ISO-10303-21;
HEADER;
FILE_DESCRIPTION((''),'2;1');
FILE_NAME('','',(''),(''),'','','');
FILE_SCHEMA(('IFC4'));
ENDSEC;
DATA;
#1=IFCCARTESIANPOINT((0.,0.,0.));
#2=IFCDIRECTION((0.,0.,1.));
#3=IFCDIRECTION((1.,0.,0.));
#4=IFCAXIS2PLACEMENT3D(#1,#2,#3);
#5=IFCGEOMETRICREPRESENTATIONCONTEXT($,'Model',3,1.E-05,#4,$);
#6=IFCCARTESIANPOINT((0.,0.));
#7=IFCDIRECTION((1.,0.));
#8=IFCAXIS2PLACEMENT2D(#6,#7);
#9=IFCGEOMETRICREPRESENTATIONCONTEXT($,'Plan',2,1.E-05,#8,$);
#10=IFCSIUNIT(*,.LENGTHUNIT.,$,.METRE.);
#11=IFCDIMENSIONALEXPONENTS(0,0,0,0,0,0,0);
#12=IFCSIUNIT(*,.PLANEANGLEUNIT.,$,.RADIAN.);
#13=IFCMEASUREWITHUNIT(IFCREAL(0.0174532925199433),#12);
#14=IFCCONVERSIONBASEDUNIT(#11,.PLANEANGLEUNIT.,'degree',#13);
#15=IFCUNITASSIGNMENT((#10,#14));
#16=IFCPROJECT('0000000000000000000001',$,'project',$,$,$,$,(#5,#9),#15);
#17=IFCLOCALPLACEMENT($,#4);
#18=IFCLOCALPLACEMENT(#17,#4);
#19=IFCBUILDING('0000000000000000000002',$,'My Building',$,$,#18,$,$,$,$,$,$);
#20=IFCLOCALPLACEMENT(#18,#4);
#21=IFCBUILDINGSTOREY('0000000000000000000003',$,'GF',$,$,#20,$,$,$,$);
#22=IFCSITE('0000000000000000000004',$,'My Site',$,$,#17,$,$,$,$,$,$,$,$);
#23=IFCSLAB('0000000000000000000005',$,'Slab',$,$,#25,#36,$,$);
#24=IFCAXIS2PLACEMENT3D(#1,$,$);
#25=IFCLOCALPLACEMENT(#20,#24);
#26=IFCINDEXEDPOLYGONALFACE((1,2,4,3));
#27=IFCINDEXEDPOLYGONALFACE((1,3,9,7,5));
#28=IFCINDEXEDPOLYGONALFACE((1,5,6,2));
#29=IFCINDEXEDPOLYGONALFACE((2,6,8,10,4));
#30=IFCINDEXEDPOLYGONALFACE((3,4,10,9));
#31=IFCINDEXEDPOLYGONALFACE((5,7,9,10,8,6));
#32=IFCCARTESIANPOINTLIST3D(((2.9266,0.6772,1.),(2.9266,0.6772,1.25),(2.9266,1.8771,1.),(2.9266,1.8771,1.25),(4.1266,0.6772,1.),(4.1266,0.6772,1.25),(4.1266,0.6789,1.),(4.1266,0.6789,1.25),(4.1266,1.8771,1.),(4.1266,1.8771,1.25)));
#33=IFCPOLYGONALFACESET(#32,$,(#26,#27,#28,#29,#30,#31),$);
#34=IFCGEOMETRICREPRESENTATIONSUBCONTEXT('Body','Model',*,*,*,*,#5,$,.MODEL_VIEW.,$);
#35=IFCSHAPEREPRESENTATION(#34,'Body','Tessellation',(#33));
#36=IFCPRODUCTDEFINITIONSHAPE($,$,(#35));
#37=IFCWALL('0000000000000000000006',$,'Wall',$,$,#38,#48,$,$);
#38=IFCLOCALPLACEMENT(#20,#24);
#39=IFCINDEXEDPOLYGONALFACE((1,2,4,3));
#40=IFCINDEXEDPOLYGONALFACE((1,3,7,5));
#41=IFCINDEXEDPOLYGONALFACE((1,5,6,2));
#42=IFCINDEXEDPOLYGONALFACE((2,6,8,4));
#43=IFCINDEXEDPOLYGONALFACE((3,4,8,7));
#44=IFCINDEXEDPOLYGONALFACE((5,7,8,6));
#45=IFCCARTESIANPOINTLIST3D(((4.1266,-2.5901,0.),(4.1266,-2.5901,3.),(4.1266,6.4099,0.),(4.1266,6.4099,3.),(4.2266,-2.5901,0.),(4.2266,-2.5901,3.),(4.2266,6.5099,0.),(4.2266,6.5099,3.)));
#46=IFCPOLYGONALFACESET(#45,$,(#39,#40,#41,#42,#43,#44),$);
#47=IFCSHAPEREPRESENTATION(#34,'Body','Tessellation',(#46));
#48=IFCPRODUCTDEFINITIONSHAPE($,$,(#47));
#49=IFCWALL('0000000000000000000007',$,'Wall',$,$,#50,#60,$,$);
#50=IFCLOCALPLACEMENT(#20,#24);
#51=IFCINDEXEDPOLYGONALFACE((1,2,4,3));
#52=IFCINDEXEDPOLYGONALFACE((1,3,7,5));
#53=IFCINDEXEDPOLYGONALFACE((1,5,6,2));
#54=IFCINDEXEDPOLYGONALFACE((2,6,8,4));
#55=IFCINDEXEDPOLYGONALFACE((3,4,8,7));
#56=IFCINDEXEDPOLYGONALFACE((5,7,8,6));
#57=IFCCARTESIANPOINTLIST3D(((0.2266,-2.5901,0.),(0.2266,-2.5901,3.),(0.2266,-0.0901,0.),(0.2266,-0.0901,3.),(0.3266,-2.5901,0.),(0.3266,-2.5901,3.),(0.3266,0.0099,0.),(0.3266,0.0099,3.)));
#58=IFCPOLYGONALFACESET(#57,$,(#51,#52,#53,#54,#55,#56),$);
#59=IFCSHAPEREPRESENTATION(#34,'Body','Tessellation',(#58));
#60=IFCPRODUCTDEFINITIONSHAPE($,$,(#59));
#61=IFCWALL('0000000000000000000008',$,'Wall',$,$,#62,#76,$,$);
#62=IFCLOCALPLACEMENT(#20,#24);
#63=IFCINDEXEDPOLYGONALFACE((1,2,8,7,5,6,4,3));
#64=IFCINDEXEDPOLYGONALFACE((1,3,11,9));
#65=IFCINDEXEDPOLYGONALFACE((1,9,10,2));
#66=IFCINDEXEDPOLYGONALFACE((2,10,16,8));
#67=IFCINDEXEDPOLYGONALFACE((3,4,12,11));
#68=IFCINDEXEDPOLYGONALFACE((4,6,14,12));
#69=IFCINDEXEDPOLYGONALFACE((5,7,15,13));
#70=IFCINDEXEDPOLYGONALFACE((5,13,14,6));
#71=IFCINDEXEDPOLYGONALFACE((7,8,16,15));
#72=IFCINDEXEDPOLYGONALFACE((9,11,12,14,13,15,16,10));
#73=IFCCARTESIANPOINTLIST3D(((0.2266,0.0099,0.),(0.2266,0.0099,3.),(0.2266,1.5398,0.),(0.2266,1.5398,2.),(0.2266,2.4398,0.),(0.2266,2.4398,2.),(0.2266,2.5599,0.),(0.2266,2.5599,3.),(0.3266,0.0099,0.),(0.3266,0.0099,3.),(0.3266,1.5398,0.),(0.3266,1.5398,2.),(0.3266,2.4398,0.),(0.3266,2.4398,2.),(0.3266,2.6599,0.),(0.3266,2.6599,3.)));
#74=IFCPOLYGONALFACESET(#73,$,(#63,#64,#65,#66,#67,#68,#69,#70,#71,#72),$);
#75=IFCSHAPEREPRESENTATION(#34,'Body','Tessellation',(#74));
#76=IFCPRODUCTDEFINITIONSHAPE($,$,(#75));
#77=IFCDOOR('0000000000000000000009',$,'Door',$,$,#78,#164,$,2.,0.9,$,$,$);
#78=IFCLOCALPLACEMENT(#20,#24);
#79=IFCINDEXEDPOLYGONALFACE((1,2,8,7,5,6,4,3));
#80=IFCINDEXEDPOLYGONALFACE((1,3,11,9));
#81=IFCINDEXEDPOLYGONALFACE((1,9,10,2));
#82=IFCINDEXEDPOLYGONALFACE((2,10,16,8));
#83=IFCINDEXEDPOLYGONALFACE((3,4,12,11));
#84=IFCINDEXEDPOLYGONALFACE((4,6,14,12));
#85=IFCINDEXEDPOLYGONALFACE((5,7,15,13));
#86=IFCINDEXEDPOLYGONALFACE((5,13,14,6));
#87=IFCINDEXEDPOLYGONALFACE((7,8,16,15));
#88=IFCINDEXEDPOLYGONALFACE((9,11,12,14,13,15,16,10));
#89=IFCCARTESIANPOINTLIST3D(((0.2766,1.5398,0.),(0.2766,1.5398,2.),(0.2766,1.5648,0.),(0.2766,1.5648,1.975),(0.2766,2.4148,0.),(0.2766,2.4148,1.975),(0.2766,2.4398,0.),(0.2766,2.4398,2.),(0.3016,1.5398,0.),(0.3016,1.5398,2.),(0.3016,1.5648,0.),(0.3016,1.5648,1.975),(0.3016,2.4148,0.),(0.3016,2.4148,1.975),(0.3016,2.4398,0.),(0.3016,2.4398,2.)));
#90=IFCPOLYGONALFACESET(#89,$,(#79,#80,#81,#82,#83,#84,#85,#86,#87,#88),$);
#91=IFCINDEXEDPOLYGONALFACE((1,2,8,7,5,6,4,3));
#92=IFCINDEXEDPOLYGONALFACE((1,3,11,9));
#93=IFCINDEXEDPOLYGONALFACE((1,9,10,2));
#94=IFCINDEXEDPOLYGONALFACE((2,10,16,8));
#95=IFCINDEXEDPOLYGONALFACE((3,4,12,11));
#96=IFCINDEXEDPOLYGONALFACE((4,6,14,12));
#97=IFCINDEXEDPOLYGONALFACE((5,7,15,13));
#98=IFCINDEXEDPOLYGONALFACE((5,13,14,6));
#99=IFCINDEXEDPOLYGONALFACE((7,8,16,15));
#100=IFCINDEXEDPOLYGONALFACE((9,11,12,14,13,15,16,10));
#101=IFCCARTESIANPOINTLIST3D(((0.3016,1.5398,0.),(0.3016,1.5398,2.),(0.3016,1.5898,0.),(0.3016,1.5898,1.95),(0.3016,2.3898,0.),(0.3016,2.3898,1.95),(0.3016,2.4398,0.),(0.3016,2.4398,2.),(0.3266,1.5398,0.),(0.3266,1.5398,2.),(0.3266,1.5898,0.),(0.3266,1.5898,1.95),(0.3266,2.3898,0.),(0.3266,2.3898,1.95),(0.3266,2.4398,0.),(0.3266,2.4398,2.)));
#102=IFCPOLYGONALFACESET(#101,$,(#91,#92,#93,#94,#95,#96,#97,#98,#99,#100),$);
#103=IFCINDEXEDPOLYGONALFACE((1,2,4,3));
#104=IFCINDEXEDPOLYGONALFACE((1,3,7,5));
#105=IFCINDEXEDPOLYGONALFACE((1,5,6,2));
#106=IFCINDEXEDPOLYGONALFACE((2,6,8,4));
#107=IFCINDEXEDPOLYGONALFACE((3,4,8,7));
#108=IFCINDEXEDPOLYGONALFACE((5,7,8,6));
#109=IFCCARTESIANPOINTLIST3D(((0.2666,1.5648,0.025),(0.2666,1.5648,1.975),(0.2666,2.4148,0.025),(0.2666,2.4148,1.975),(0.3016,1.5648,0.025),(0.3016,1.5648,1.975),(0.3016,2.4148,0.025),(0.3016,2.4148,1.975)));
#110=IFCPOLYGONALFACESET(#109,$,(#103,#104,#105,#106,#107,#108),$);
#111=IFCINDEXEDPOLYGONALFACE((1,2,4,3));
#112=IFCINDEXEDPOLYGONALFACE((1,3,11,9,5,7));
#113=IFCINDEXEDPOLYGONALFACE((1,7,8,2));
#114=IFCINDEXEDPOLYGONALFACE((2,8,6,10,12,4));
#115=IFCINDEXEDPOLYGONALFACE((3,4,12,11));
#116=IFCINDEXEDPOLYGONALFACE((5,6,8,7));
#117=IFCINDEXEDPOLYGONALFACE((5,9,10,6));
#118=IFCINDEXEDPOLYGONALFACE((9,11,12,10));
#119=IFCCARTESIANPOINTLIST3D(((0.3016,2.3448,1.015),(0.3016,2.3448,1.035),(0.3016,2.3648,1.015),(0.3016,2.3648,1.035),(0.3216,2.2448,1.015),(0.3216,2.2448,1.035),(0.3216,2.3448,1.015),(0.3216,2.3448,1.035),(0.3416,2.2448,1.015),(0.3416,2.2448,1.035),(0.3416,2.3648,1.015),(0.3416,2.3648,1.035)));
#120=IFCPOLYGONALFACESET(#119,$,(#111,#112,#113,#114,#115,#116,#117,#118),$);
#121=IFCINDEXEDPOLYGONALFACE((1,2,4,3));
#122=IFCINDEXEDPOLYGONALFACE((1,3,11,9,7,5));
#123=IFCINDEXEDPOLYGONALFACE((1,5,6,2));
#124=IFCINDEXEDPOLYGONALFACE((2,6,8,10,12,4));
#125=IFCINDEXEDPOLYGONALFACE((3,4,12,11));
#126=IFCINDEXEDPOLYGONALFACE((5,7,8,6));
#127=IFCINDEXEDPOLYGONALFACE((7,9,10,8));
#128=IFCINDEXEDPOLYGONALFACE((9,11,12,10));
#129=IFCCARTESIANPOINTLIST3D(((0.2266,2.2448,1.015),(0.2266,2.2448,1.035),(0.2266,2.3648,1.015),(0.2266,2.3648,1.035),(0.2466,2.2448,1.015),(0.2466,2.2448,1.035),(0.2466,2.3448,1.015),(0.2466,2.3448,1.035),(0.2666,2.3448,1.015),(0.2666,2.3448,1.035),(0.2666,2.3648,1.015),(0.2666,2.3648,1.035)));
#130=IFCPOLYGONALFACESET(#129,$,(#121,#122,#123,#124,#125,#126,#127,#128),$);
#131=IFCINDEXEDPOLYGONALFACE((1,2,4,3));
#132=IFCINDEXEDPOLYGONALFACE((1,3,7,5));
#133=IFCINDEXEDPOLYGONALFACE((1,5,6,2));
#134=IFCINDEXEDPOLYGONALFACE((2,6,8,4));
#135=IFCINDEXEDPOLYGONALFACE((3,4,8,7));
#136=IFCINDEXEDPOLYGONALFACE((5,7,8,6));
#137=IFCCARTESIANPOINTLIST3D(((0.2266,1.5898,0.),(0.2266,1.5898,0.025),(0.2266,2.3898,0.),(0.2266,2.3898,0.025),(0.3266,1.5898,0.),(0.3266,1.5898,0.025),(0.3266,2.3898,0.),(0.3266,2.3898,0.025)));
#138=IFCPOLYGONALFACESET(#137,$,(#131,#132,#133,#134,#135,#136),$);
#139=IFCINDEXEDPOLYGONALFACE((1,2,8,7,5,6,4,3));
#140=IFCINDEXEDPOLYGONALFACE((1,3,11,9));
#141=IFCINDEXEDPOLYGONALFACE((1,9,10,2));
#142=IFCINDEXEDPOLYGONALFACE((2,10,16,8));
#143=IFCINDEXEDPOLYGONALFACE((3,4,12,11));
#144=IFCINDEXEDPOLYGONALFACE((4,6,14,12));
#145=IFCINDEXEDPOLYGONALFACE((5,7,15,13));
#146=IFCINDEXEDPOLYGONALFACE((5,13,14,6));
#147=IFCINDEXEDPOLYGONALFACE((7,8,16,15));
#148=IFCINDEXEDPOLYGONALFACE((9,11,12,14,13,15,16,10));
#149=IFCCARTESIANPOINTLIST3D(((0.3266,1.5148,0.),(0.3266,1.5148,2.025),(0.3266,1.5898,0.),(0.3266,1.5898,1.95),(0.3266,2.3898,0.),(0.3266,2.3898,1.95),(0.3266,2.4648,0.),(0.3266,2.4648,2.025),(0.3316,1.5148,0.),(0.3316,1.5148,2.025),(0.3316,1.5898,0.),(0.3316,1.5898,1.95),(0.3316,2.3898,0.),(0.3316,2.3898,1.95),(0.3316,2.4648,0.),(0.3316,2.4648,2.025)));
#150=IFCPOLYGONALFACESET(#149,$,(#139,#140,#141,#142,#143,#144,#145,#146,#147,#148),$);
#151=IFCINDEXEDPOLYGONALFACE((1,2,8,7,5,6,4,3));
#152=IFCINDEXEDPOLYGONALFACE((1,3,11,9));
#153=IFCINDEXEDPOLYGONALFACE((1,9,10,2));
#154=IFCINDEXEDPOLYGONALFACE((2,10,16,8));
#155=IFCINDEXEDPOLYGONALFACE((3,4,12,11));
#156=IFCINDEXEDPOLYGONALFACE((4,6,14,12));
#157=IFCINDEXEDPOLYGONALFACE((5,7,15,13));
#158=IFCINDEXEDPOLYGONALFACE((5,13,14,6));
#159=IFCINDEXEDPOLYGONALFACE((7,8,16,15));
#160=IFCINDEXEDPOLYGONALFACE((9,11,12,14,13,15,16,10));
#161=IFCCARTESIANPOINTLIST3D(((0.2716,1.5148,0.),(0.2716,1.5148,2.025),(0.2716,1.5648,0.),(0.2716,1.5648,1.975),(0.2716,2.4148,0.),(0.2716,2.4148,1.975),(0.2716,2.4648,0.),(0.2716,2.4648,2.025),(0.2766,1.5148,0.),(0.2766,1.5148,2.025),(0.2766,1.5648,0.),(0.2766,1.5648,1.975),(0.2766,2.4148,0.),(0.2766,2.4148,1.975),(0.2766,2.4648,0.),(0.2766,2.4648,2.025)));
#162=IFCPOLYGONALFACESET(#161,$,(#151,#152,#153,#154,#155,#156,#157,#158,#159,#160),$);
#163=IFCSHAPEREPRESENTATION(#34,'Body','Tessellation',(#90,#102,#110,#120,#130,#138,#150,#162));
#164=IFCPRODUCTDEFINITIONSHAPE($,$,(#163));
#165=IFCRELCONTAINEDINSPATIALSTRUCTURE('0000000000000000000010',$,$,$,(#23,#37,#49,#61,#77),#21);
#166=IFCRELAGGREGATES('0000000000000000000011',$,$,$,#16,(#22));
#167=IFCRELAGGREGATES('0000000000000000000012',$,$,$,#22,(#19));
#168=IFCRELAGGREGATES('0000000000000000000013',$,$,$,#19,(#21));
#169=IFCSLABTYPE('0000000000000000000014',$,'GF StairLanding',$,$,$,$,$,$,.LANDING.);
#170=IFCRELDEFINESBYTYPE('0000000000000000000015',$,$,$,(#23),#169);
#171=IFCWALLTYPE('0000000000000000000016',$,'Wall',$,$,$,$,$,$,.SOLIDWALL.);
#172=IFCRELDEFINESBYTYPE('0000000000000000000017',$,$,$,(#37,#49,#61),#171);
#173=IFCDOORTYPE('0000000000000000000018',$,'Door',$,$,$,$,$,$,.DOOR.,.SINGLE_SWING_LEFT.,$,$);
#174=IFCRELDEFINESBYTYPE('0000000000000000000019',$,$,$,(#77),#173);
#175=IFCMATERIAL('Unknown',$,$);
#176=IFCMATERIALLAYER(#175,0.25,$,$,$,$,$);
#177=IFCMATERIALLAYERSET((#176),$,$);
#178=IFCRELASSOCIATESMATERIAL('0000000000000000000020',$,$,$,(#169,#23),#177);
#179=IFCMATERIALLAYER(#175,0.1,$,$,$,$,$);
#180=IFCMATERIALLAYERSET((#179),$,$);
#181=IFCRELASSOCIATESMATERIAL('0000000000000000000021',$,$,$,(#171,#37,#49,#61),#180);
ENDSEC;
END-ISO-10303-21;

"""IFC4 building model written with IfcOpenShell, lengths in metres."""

from ifc_helpers import new_model, entity, si_unit, converted_unit, frame, origin_with_axes, origin_2d_with_axis, place, context, subcontext, project, spatial, line, indexed_curve, outline, extrude, shape, source, transform, mapped, material, layer, layer_set, layer_usage, type_object, type_shapes, element, fill, save


model = new_model("IFC4")

# Units and contexts
model_context = context("Model", 3, precision=1e-05, world=origin_with_axes())
plan_context = context("Plan", 2, precision=1e-05, world=origin_2d_with_axis())
body_context_1 = subcontext(model_context, "Body", "Model", "MODEL_VIEW")
body_context_2 = subcontext(plan_context, "Body", "Plan", "PLAN_VIEW")
ifc_project = project(units=[si_unit("LENGTHUNIT", "METRE"), converted_unit("PLANEANGLEUNIT", "degree", entity("IfcReal", 0.0174532925199433), si_unit("PLANEANGLEUNIT", "RADIAN"), dimensions=[0, 0, 0, 0, 0, 0, 0])], contexts=[model_context, plan_context])

# Site, building, storey
site_placement = place(None, origin_with_axes())
site = spatial("IfcSite", under=ifc_project, at=site_placement, Name="My Site")
building_placement = place(site_placement, origin_with_axes())
building = spatial("IfcBuilding", under=site, at=building_placement, Name="My Building")
storey_placement = place(building_placement, origin_with_axes())
storey = spatial("IfcBuildingStorey", under=building, at=storey_placement, Name="GF")

# Shared definitions
ifc_material = material(Name="Unknown")

# Slab
ifc_layer_1 = layer(ifc_material, 0.25)
ifc_layer_set_1 = layer_set([ifc_layer_1])
ifc_layer_usage_1 = layer_usage(ifc_layer_set_1, "AXIS3", "POSITIVE", -0.1)
slab_type_1 = type_object("IfcSlabType", Name="GF StairLanding", PredefinedType="LANDING", material=ifc_layer_set_1)
slab_1_placement = place(storey_placement, frame((2.9266, 1.8771, 1.1), z_axis=(0.0, 0.0, 1.0), x_axis=(1.0, 0.0, 0.0)))
element("IfcSlab", 1, at=slab_1_placement, inside=storey, type_object=slab_type_1, material=ifc_layer_usage_1, Name="Slab", context=body_context_1, shape_type="SweptSolid", body=[
    extrude(outline(indexed_curve([(0.0, 0.0), (1.1999, 0.0), (1.1999, -1.1982), (1.1999, -1.1999), (0.0, -1.1999), (0.0, 0.0)])), frame((0.0, 0.0, -0.1), z_axis=(0.0, 0.0, 1.0), x_axis=(1.0, 0.0, 0.0)), (0.0, 0.0, 1.0), 0.25),
])

# Shared definitions
ifc_layer_2 = layer(ifc_material, 0.1)
ifc_layer_set_2 = layer_set([ifc_layer_2])
wall_type = type_object("IfcWallType", Name="Wall", PredefinedType="SOLIDWALL", material=ifc_layer_set_2)
shared_shape_1 = source(origin_with_axes(), body_context_1, "Body", "SweptSolid", [
    extrude(outline(indexed_curve([(0.0, 0.0), (0.9, 0.0), (0.9, 2.0), (0.0, 2.0)], segments=[line(1, 2, 3, 4, 1)])), frame((0.0, -0.6, 0.0), z_axis=(0.0, -1.0, 0.0), x_axis=(1.0, 0.0, 0.0)), (0.0, 0.0, -1.0), 1.2),
])
door_type = type_object("IfcDoorType", Name="Door", OperationType="SINGLE_SWING_LEFT", PredefinedType="DOOR")
shared_shape_2 = source(origin_with_axes(), body_context_1, "Body", "SweptSolid", [
    extrude(outline(indexed_curve([(0.0, 0.0), (0.0, 2.0), (0.9, 2.0), (0.9, 0.0), (0.875, 0.0), (0.875, 1.975), (0.025, 1.975), (0.025, 0.0)], segments=[line(1, 2, 3, 4, 5, 6, 7, 8, 1)])), frame((0.0, 0.025, 0.0), z_axis=(0.0, -1.0, 0.0), x_axis=(1.0, 0.0, 0.0)), (0.0, 0.0, -1.0), 0.025),
    extrude(outline(indexed_curve([(0.0, 0.0), (0.0, 2.0), (0.9, 2.0), (0.9, 0.0), (0.85, 0.0), (0.85, 1.95), (0.05, 1.95), (0.05, 0.0)], segments=[line(1, 2, 3, 4, 5, 6, 7, 8, 1)])), frame((0.0, 0.0, 0.0), z_axis=(0.0, -1.0, 0.0), x_axis=(1.0, 0.0, 0.0)), (0.0, 0.0, -1.0), 0.025),
    extrude(outline(indexed_curve([(0.0, 0.0), (0.85, 0.0), (0.85, 0.035), (0.0, 0.035)], segments=[line(1, 2, 3, 4, 1)])), frame((0.025, 0.025, 0.025), z_axis=(0.0, 0.0, 1.0), x_axis=(1.0, 0.0, 0.0)), (0.0, 0.0, 1.0), 1.95),
    extrude(outline(indexed_curve([(0.0, 0.0), (0.0, -0.04), (-0.12, -0.04), (-0.12, -0.02), (-0.02, -0.02), (-0.02, 0.0)], segments=[line(1, 2, 3, 4, 5, 6, 1)])), frame((0.825, 0.025, 1.015), z_axis=(0.0, 0.0, 1.0), x_axis=(1.0, 0.0, 0.0)), (0.0, 0.0, 1.0), 0.02),
    extrude(outline(indexed_curve([(0.0, 0.0), (0.0, 0.04), (-0.12, 0.04), (-0.12, 0.02), (-0.02, 0.02), (-0.02, 0.0)], segments=[line(1, 2, 3, 4, 5, 6, 1)])), frame((0.825, 0.06, 1.015), z_axis=(0.0, 0.0, 1.0), x_axis=(1.0, 0.0, 0.0)), (0.0, 0.0, 1.0), 0.02),
    extrude(outline(indexed_curve([(0.0, 0.0), (0.8, 0.0), (0.8, 0.1), (0.0, 0.1)], segments=[line(1, 2, 3, 4, 1)])), frame((0.05, 0.0, 0.0), z_axis=(0.0, 0.0, 1.0), x_axis=(1.0, 0.0, 0.0)), (0.0, 0.0, 1.0), 0.025),
    extrude(outline(indexed_curve([(0.0, 0.0), (0.0, 2.025), (0.95, 2.025), (0.95, 0.0), (0.875, 0.0), (0.875, 1.95), (0.075, 1.95), (0.075, 0.0)], segments=[line(1, 2, 3, 4, 5, 6, 7, 8, 1)])), frame((-0.025, -0.005, 0.0), z_axis=(0.0, -1.0, 0.0), x_axis=(1.0, 0.0, 0.0)), (0.0, 0.0, -1.0), 0.005),
    extrude(outline(indexed_curve([(0.0, 0.0), (0.0, 2.025), (0.95, 2.025), (0.95, 0.0), (0.9, 0.0), (0.9, 1.975), (0.05, 1.975), (0.05, 0.0)], segments=[line(1, 2, 3, 4, 5, 6, 7, 8, 1)])), frame((-0.025, 0.05, 0.0), z_axis=(0.0, -1.0, 0.0), x_axis=(1.0, 0.0, 0.0)), (0.0, 0.0, -1.0), 0.005),
])
shared_shape_3 = source(origin_with_axes(), body_context_2, "Body", "Curve2D", [
    entity("IfcIndexedPolyCurve", entity("IfcCartesianPointList2D", [[0.0, 0.0], [0.0, 0.05], [0.025, 0.05], [0.025, 0.025], [0.05, 0.025], [0.05, 0.0]]), [entity("IfcLineIndex", [1, 2, 3, 4, 5, 6, 1])]),
    entity("IfcIndexedPolyCurve", entity("IfcCartesianPointList2D", [[0.9, 0.0], [0.9, 0.05], [0.875, 0.05], [0.875, 0.025], [0.85, 0.025], [0.85, 0.0]]), [entity("IfcLineIndex", [1, 2, 3, 4, 5, 6, 1])]),
    entity("IfcTrimmedCurve", entity("IfcEllipse", entity("IfcAxis2Placement2D", entity("IfcCartesianPoint", [0.06, 0.05]), entity("IfcDirection", [1.0, 0.0])), 0.815, 0.85), [entity("IfcCartesianPoint", [0.875, 0.05])], [entity("IfcCartesianPoint", [0.06, 0.9])], True, "CARTESIAN"),
    entity("IfcIndexedPolyCurve", entity("IfcCartesianPointList2D", [[0.025, 0.05], [0.06, 0.05], [0.06, 0.9], [0.025, 0.9]]), [entity("IfcLineIndex", [1, 2, 3, 4, 1])]),
])
type_shapes(door_type, [shared_shape_2, shared_shape_3])

# Walls
ifc_layer_usage_2 = layer_usage(ifc_layer_set_2, "AXIS2", "POSITIVE", 0.0)
wall_1_placement = place(storey_placement, frame((4.2266, -2.5901, 0.0), z_axis=(0.0, 0.0, 1.0), x_axis=(0.0, 1.0, 0.0)))
element("IfcWall", 2, at=wall_1_placement, inside=storey, type_object=wall_type, material=ifc_layer_usage_2, Name="Wall", context=body_context_1, shape_type="SweptSolid", body=[
    extrude(outline(indexed_curve([(0.0, 0.0), (0.0, 0.1), (9.0, 0.1), (9.1, 0.0)], segments=[line(1, 2, 3, 4, 1)])), origin_with_axes(), (0.0, 0.0, 1.0), 3.0),
])
ifc_layer_usage_3 = layer_usage(ifc_layer_set_2, "AXIS2", "POSITIVE", 0.0)
wall_2_placement = place(storey_placement, frame((0.2266, -0.0901, 0.0), z_axis=(0.0, 0.0, 1.0), x_axis=(0.0, -1.0, 0.0)))
element("IfcWall", 3, at=wall_2_placement, inside=storey, type_object=wall_type, material=ifc_layer_usage_3, Name="Wall", context=body_context_1, shape_type="SweptSolid", body=[
    extrude(outline(indexed_curve([(0.0, 0.0), (-0.1, 0.1), (2.5, 0.1), (2.5, 0.0)], segments=[line(1, 2, 3, 4, 1)])), origin_with_axes(), (0.0, 0.0, 1.0), 3.0),
])

# Wall, opening, door
ifc_layer_usage_4 = layer_usage(ifc_layer_set_2, "AXIS2", "POSITIVE", 0.0)
wall_3_placement = place(storey_placement, frame((0.3266, 0.0099, 0.0), z_axis=(0.0, 0.0, 1.0), x_axis=(0.0, 1.0, 0.0)))
wall_3 = element("IfcWall", 4, at=wall_3_placement, inside=storey, type_object=wall_type, material=ifc_layer_usage_4, Name="Wall", context=body_context_1, shape_type="SweptSolid", body=[
    extrude(outline(indexed_curve([(0.0, 0.0), (0.0, 0.1), (2.55, 0.1), (2.65, 0.0)], segments=[line(1, 2, 3, 4, 1)])), origin_with_axes(), (0.0, 0.0, 1.0), 3.0),
])
opening_1_placement = place(wall_3_placement, frame((1.5299, 0.0, 0.0), z_axis=(0.0, 0.0, 1.0), x_axis=(1.0, 0.0, 0.0)))
opening_1 = element("IfcOpeningElement", 5, at=opening_1_placement, cuts=wall_3, PredefinedType="OPENING", context=body_context_1, shape_type="MappedRepresentation", body=[
    mapped(shared_shape_1, transform((0.0, 0.0, 0.0), x_axis=(1.0, 0.0, 0.0), y_axis=(0.0, 1.0, 0.0), z_axis=(0.0, 0.0, 1.0), scale=1.0)),
])
door_1_placement = place(opening_1_placement, frame((0.0, 0.0, 0.0), z_axis=(0.0, 0.0, 1.0), x_axis=(1.0, 0.0, 0.0)))
door_1 = element("IfcDoor", 6, at=door_1_placement, inside=storey, type_object=door_type, Name="Door", OverallHeight=2.0, OverallWidth=0.9, shapes=[
    shape(body_context_1, "Body", "MappedRepresentation", [mapped(shared_shape_2, transform((0.0, 0.0, 0.0), x_axis=(1.0, 0.0, 0.0), y_axis=(0.0, 1.0, 0.0), z_axis=(0.0, 0.0, 1.0), scale=1.0))]),
    shape(body_context_2, "Body", "MappedRepresentation", [mapped(shared_shape_3, transform((0.0, 0.0, 0.0), x_axis=(1.0, 0.0, 0.0), y_axis=(0.0, 1.0, 0.0), z_axis=(0.0, 0.0, 1.0), scale=1.0))]),
])
fill(opening_1, door_1)

save(model, "model.ifc")
